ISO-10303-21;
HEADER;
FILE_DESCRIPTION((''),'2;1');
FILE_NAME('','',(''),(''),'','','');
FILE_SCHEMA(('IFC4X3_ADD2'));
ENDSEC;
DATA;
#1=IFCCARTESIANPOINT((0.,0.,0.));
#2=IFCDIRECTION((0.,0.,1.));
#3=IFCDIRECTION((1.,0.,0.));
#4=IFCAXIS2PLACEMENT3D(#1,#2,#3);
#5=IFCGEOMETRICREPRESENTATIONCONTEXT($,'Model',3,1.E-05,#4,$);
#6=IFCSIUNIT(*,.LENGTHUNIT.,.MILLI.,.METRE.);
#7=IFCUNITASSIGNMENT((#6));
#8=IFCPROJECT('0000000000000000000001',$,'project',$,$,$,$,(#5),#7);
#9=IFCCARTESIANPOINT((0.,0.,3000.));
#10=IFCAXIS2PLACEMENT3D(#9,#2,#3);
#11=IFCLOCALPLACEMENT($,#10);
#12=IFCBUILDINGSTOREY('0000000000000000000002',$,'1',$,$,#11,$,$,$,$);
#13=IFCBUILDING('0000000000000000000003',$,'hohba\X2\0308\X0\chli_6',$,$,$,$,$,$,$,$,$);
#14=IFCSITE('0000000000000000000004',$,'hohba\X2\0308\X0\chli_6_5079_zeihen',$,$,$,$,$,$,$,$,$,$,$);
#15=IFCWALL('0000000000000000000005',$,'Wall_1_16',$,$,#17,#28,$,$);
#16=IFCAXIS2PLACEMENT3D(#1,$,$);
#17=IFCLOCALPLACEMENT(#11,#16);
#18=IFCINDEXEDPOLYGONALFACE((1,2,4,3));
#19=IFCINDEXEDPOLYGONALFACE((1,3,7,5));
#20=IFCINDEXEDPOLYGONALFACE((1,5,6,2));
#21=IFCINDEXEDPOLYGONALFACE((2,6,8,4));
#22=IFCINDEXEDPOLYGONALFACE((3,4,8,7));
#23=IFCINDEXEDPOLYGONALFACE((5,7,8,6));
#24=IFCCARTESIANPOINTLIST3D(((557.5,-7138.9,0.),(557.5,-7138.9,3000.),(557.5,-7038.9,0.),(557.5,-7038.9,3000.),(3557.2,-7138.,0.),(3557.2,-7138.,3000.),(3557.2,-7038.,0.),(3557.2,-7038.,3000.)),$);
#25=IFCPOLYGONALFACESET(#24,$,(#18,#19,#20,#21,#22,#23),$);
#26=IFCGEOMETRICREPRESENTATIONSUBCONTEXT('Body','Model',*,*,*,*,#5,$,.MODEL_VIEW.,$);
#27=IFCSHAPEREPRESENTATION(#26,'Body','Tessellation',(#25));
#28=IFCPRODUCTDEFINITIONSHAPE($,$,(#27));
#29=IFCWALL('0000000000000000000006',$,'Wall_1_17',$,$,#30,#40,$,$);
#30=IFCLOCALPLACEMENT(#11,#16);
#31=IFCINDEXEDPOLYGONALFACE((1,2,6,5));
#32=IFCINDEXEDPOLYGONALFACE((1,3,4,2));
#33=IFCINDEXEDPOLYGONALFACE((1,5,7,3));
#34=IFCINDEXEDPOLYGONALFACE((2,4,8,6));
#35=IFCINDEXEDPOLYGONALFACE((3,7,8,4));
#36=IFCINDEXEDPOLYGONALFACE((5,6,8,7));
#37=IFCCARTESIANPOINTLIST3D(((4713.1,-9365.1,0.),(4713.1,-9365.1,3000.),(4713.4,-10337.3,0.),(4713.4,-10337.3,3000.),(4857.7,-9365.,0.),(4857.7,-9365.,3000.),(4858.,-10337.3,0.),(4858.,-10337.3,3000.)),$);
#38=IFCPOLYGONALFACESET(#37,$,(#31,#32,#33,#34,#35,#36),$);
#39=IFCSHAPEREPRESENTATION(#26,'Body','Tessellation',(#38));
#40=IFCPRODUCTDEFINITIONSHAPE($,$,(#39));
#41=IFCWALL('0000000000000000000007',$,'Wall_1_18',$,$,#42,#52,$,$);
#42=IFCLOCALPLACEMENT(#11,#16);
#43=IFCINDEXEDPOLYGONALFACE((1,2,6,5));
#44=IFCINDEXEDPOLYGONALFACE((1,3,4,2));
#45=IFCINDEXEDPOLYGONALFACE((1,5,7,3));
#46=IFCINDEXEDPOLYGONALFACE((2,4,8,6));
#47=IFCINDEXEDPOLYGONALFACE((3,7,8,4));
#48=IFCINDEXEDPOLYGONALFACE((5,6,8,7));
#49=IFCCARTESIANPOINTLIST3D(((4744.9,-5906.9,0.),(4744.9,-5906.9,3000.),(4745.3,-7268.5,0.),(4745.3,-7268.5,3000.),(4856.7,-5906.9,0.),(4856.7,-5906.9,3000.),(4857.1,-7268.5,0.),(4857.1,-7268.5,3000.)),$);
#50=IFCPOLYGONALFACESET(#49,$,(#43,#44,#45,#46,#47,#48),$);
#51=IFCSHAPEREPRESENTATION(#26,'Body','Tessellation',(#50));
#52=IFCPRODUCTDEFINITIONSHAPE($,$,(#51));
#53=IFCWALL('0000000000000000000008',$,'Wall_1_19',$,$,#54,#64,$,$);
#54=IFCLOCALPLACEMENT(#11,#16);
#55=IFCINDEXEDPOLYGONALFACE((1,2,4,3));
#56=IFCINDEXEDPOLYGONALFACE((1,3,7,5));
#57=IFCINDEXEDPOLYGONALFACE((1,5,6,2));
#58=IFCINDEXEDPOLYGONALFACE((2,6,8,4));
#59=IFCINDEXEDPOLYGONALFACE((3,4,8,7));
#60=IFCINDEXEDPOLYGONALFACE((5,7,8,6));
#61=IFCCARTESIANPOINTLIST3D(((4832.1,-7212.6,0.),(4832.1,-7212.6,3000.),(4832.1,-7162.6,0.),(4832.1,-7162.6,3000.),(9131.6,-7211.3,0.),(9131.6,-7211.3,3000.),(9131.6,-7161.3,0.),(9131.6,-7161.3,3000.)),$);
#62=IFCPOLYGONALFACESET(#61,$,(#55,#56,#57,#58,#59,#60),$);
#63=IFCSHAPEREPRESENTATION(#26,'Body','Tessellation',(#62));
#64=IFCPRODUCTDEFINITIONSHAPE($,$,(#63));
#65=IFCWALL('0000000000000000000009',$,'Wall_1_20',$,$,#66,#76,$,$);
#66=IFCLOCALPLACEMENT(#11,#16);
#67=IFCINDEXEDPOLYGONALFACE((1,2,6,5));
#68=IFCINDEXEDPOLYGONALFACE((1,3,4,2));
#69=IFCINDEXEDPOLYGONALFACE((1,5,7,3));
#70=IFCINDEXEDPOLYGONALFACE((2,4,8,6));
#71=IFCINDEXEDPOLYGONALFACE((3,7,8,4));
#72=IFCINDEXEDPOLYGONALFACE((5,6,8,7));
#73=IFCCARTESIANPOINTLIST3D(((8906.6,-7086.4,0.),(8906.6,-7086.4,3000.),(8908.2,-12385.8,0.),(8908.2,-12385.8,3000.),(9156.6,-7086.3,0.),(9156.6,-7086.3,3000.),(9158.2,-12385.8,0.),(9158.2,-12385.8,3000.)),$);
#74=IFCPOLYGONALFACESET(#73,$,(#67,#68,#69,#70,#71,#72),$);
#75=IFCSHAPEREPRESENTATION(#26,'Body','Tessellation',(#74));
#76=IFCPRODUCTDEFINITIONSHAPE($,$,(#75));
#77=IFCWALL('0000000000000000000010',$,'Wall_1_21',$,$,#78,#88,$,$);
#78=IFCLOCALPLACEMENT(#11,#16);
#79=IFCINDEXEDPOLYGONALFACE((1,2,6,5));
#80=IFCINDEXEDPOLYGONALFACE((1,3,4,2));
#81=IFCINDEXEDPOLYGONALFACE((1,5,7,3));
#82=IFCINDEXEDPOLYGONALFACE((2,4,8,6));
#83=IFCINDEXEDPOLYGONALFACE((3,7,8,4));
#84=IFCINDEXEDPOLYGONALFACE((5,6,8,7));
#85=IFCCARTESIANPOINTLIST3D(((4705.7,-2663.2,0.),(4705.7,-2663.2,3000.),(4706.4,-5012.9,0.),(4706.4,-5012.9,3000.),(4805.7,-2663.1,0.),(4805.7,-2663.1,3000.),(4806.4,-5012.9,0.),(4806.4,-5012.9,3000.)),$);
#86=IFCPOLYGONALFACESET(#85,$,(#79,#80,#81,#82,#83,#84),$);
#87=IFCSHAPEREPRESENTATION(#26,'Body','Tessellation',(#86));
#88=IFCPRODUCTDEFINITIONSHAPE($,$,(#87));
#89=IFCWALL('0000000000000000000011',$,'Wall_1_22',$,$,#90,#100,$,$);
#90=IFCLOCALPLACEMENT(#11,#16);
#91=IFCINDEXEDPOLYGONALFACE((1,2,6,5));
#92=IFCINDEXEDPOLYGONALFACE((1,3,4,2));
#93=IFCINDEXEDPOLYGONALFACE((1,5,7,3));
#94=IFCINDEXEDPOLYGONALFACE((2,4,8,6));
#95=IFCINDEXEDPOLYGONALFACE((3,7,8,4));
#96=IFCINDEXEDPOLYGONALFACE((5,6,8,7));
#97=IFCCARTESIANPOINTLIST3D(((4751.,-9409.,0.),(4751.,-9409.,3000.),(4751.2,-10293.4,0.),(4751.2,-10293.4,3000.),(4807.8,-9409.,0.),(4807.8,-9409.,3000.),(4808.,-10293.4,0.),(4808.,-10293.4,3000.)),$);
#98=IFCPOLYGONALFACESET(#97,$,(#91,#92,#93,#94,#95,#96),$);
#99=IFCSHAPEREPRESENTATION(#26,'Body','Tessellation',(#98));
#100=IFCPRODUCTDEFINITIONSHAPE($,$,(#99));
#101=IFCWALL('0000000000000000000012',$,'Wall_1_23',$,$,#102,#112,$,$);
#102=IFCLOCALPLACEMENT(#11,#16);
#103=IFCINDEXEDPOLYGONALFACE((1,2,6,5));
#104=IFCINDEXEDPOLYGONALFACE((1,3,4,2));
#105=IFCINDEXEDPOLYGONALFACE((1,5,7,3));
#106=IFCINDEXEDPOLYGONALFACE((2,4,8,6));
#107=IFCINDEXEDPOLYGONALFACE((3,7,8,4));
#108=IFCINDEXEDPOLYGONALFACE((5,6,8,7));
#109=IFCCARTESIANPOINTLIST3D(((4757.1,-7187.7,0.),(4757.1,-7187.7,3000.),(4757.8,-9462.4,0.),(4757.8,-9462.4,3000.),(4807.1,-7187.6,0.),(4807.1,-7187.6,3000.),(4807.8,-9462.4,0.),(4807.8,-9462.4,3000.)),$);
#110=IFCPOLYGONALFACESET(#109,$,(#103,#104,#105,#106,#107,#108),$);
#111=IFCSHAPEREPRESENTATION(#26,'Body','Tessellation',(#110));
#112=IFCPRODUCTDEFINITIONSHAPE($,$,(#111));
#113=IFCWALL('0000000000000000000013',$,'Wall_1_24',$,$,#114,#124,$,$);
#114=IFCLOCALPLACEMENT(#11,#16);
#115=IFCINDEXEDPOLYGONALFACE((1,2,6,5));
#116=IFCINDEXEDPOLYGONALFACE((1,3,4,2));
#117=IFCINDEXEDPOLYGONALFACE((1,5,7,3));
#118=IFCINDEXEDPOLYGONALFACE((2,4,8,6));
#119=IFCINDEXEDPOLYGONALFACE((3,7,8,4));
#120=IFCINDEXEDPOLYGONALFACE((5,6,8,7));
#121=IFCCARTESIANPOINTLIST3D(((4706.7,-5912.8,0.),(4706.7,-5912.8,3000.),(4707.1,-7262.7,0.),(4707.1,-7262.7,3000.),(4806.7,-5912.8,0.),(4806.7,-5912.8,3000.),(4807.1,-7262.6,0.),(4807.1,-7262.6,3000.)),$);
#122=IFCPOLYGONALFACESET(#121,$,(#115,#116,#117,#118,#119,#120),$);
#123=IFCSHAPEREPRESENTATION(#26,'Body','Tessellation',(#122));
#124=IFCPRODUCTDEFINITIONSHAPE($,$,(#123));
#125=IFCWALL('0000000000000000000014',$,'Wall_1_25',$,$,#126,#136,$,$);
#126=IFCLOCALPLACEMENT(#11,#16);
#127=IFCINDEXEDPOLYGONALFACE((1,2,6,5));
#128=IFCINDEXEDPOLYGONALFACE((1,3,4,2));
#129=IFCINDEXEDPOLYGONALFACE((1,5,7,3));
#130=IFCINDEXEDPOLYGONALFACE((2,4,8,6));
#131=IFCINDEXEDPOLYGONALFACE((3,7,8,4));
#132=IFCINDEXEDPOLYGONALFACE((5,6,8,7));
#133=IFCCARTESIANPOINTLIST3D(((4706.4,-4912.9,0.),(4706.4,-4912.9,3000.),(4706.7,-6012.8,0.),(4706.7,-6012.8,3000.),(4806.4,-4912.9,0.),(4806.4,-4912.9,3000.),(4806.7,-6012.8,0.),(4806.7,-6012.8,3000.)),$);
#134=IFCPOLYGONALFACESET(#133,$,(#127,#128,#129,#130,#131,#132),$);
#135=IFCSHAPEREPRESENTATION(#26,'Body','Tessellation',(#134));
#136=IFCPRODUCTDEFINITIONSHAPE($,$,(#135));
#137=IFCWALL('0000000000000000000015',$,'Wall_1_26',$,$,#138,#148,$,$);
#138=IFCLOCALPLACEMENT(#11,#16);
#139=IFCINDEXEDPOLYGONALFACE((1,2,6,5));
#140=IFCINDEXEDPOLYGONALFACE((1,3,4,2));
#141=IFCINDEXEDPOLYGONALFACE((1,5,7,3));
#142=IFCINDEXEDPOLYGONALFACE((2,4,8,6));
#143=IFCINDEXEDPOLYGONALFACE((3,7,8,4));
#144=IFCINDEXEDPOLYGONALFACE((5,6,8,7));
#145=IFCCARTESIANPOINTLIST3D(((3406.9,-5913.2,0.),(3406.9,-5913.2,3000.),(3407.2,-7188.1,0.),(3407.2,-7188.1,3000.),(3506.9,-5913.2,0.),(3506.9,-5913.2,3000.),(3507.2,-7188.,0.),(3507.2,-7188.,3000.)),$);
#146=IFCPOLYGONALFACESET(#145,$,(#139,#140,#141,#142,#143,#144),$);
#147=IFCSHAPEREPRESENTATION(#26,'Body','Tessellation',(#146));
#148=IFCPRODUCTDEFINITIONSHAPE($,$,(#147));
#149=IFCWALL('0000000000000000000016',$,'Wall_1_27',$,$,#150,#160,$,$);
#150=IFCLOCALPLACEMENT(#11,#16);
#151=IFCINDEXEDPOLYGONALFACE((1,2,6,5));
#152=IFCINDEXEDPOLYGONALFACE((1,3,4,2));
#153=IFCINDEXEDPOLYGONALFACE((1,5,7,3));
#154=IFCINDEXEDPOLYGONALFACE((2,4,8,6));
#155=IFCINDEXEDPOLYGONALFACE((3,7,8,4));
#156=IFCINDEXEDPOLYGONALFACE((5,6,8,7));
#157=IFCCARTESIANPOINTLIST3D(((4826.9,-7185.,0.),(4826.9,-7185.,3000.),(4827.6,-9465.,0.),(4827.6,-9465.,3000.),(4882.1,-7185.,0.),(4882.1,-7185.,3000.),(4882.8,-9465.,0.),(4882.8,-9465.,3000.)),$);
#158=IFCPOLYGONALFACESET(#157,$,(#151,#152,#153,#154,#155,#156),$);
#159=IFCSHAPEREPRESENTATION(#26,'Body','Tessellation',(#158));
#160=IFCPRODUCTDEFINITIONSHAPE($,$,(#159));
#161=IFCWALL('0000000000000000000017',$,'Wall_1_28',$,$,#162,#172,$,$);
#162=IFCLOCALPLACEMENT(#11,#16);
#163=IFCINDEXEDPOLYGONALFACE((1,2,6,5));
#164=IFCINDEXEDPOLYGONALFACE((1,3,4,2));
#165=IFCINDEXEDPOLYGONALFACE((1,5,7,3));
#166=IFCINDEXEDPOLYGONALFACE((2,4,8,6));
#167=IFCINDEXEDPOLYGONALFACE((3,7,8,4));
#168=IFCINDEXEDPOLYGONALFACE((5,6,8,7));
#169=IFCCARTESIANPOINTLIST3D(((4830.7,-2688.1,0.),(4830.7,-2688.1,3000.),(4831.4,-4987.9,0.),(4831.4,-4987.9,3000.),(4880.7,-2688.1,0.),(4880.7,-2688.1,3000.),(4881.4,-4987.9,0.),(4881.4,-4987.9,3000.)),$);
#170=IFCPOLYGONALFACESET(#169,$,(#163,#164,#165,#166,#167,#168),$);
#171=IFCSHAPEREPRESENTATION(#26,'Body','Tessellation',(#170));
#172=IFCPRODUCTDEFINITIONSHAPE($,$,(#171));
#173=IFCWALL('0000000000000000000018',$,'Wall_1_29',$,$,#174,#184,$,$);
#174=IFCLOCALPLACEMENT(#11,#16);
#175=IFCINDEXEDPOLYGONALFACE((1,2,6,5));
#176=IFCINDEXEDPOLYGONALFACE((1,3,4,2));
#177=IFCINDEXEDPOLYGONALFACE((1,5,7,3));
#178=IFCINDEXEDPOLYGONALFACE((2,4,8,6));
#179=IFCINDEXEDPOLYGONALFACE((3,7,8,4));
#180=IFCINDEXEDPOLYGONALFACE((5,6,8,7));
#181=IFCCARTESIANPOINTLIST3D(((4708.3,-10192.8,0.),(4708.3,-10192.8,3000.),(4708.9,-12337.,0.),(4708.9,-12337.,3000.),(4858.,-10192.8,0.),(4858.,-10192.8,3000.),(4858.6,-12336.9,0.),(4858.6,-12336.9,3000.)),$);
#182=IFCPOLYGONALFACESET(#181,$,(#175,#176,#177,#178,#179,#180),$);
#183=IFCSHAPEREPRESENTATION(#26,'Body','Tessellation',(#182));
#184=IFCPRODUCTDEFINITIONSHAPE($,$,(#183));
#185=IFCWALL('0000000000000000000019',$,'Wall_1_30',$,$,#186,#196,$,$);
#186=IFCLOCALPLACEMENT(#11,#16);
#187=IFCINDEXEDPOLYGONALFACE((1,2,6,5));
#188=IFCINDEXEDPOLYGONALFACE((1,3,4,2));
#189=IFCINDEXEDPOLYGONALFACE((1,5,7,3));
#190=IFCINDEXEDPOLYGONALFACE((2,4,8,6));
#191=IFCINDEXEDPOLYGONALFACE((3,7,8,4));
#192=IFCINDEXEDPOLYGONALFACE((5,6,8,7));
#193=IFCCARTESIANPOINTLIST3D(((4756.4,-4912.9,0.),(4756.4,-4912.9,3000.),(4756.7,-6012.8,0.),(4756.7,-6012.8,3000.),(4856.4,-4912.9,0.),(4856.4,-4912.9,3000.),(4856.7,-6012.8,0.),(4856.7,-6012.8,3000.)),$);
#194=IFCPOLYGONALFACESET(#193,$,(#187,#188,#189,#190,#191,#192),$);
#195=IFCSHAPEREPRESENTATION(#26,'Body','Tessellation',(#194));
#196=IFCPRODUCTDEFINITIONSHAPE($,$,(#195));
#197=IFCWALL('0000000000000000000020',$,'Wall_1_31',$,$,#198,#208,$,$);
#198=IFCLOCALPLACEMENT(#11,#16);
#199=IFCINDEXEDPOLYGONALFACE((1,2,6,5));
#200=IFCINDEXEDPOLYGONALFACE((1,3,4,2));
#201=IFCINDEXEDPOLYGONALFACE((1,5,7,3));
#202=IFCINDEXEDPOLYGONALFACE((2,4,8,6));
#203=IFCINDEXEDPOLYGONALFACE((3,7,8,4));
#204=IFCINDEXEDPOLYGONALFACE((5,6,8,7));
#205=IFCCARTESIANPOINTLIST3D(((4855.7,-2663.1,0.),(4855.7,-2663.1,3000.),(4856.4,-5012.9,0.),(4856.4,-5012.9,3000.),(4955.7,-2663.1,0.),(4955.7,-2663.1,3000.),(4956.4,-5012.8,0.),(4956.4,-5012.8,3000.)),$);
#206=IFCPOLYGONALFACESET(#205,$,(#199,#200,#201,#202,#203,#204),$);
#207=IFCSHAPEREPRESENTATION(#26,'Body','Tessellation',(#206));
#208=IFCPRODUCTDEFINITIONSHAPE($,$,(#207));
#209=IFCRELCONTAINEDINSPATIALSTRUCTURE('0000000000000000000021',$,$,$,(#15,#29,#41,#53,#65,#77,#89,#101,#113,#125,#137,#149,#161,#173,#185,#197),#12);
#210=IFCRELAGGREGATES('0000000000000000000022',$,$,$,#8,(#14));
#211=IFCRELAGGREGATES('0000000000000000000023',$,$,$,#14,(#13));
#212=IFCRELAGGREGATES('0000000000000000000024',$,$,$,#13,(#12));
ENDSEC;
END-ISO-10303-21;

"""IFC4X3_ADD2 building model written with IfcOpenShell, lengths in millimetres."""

from ifc_helpers import new_model, si_unit, frame, origin_with_axes, place, context, subcontext, project, spatial, indexed_curve, outline, extrude, element, save


model = new_model("IFC4X3_ADD2")

# Units and contexts
model_context = context("Model", 3, precision=1e-05, world=origin_with_axes())
body_context = subcontext(model_context, "Body", "Model", "MODEL_VIEW")
ifc_project = project(units=[si_unit("LENGTHUNIT", "METRE", prefix="MILLI")], contexts=[model_context])

# Site, building, storey
site = spatial("IfcSite", under=ifc_project, Name="hohbächli_6_5079_zeihen")
building = spatial("IfcBuilding", under=site, Name="hohbächli_6")
storey_placement = place(None, frame((0.0, 0.0, 3000.0), z_axis=(0.0, 0.0, 1.0), x_axis=(1.0, 0.0, 0.0)))
storey = spatial("IfcBuildingStorey", under=building, at=storey_placement, Name="1")

# Walls
wall_1_placement = place(storey_placement, frame((557.5, -7138.9, 0.0), z_axis=(0.0, 0.0, 1.0), x_axis=(1.0, 0.000302, 0.0)))
element("IfcWall", 1, at=wall_1_placement, inside=storey, Name="Wall_1_16", context=body_context, shape_type="SweptSolid", body=[
    extrude(outline(indexed_curve([(0.0, 0.0), (0.0, 100.0), (2999.7, 100.0), (2999.7, 0.0), (0.0, 0.0)], self_intersect=False)), origin_with_axes(), (0.0, 0.0, 1.0), 3000.0),
])
wall_2_placement = place(storey_placement, frame((4858.0, -10337.3, 0.0), z_axis=(0.0, 0.0, 1.0), x_axis=(-0.000302, 1.0, 0.0)))
element("IfcWall", 2, at=wall_2_placement, inside=storey, Name="Wall_1_17", context=body_context, shape_type="SweptSolid", body=[
    extrude(outline(indexed_curve([(0.0, 0.0), (0.0, 144.7), (972.3, 144.7), (972.3, 0.0), (0.0, 0.0)], self_intersect=False)), origin_with_axes(), (0.0, 0.0, 1.0), 3000.0),
])
wall_3_placement = place(storey_placement, frame((4857.1, -7268.5, 0.0), z_axis=(0.0, 0.0, 1.0), x_axis=(-0.000302, 1.0, 0.0)))
element("IfcWall", 3, at=wall_3_placement, inside=storey, Name="Wall_1_18", context=body_context, shape_type="SweptSolid", body=[
    extrude(outline(indexed_curve([(0.0, 0.0), (0.0, 111.8), (1361.7, 111.8), (1361.7, 0.0), (0.0, 0.0)], self_intersect=False)), origin_with_axes(), (0.0, 0.0, 1.0), 3000.0),
])
wall_4_placement = place(storey_placement, frame((9131.6, -7161.3, 0.0), z_axis=(0.0, 0.0, 1.0), x_axis=(-1.0, -0.000302, 0.0)))
element("IfcWall", 4, at=wall_4_placement, inside=storey, Name="Wall_1_19", context=body_context, shape_type="SweptSolid", body=[
    extrude(outline(indexed_curve([(0.0, 0.0), (0.0, 50.0), (4299.5, 50.0), (4299.5, 0.0), (0.0, 0.0)], self_intersect=False)), origin_with_axes(), (0.0, 0.0, 1.0), 3000.0),
])
wall_5_placement = place(storey_placement, frame((9158.2, -12385.8, 0.0), z_axis=(0.0, 0.0, 1.0), x_axis=(-0.000302, 1.0, 0.0)))
element("IfcWall", 5, at=wall_5_placement, inside=storey, Name="Wall_1_20", context=body_context, shape_type="SweptSolid", body=[
    extrude(outline(indexed_curve([(0.0, 0.0), (0.0, 250.0), (5299.4, 250.0), (5299.4, 0.0), (0.0, 0.0)], self_intersect=False)), origin_with_axes(), (0.0, 0.0, 1.0), 3000.0),
])
wall_6_placement = place(storey_placement, frame((4806.4, -5012.9, 0.0), z_axis=(0.0, 0.0, 1.0), x_axis=(-0.000302, 1.0, 0.0)))
element("IfcWall", 6, at=wall_6_placement, inside=storey, Name="Wall_1_21", context=body_context, shape_type="SweptSolid", body=[
    extrude(outline(indexed_curve([(0.0, 0.0), (0.0, 100.0), (2349.7, 100.0), (2349.7, 0.0), (0.0, 0.0)], self_intersect=False)), origin_with_axes(), (0.0, 0.0, 1.0), 3000.0),
])
wall_7_placement = place(storey_placement, frame((4808.0, -10293.4, 0.0), z_axis=(0.0, 0.0, 1.0), x_axis=(-0.000302, 1.0, 0.0)))
element("IfcWall", 7, at=wall_7_placement, inside=storey, Name="Wall_1_22", context=body_context, shape_type="SweptSolid", body=[
    extrude(outline(indexed_curve([(0.0, 0.0), (0.0, 56.8), (884.4, 56.8), (884.4, 0.0), (0.0, 0.0)], self_intersect=False)), origin_with_axes(), (0.0, 0.0, 1.0), 3000.0),
])
wall_8_placement = place(storey_placement, frame((4807.8, -9462.4, 0.0), z_axis=(0.0, 0.0, 1.0), x_axis=(-0.000302, 1.0, 0.0)))
element("IfcWall", 8, at=wall_8_placement, inside=storey, Name="Wall_1_23", context=body_context, shape_type="SweptSolid", body=[
    extrude(outline(indexed_curve([(0.0, 0.0), (0.0, 50.0), (2274.8, 50.0), (2274.8, 0.0), (0.0, 0.0)], self_intersect=False)), origin_with_axes(), (0.0, 0.0, 1.0), 3000.0),
])
wall_9_placement = place(storey_placement, frame((4807.1, -7262.6, 0.0), z_axis=(0.0, 0.0, 1.0), x_axis=(-0.000302, 1.0, 0.0)))
element("IfcWall", 9, at=wall_9_placement, inside=storey, Name="Wall_1_24", context=body_context, shape_type="SweptSolid", body=[
    extrude(outline(indexed_curve([(0.0, 0.0), (0.0, 100.0), (1349.9, 100.0), (1349.9, 0.0), (0.0, 0.0)], self_intersect=False)), origin_with_axes(), (0.0, 0.0, 1.0), 3000.0),
])
wall_10_placement = place(storey_placement, frame((4806.7, -6012.8, 0.0), z_axis=(0.0, 0.0, 1.0), x_axis=(-0.000302, 1.0, 0.0)))
element("IfcWall", 10, at=wall_10_placement, inside=storey, Name="Wall_1_25", context=body_context, shape_type="SweptSolid", body=[
    extrude(outline(indexed_curve([(0.0, 0.0), (0.0, 100.0), (1099.9, 100.0), (1099.9, 0.0), (0.0, 0.0)], self_intersect=False)), origin_with_axes(), (0.0, 0.0, 1.0), 3000.0),
])
wall_11_placement = place(storey_placement, frame((3507.2, -7188.0, 0.0), z_axis=(0.0, 0.0, 1.0), x_axis=(-0.000302, 1.0, 0.0)))
element("IfcWall", 11, at=wall_11_placement, inside=storey, Name="Wall_1_26", context=body_context, shape_type="SweptSolid", body=[
    extrude(outline(indexed_curve([(0.0, 0.0), (0.0, 100.0), (1274.9, 100.0), (1274.9, 0.0), (0.0, 0.0)], self_intersect=False)), origin_with_axes(), (0.0, 0.0, 1.0), 3000.0),
])
wall_12_placement = place(storey_placement, frame((4882.8, -9465.0, 0.0), z_axis=(0.0, 0.0, 1.0), x_axis=(-0.000302, 1.0, 0.0)))
element("IfcWall", 12, at=wall_12_placement, inside=storey, Name="Wall_1_27", context=body_context, shape_type="SweptSolid", body=[
    extrude(outline(indexed_curve([(0.0, 0.0), (0.0, 55.2), (2279.9, 55.2), (2279.9, 0.0), (0.0, 0.0)], self_intersect=False)), origin_with_axes(), (0.0, 0.0, 1.0), 3000.0),
])
wall_13_placement = place(storey_placement, frame((4881.4, -4987.9, 0.0), z_axis=(0.0, 0.0, 1.0), x_axis=(-0.000302, 1.0, 0.0)))
element("IfcWall", 13, at=wall_13_placement, inside=storey, Name="Wall_1_28", context=body_context, shape_type="SweptSolid", body=[
    extrude(outline(indexed_curve([(0.0, 0.0), (0.0, 50.0), (2299.7, 50.0), (2299.7, 0.0), (0.0, 0.0)], self_intersect=False)), origin_with_axes(), (0.0, 0.0, 1.0), 3000.0),
])
wall_14_placement = place(storey_placement, frame((4858.6, -12336.9, 0.0), z_axis=(0.0, 0.0, 1.0), x_axis=(-0.000302, 1.0, 0.0)))
element("IfcWall", 14, at=wall_14_placement, inside=storey, Name="Wall_1_29", context=body_context, shape_type="SweptSolid", body=[
    extrude(outline(indexed_curve([(0.0, 0.0), (0.0, 149.7), (2144.1, 149.7), (2144.1, 0.0), (0.0, 0.0)], self_intersect=False)), origin_with_axes(), (0.0, 0.0, 1.0), 3000.0),
])
wall_15_placement = place(storey_placement, frame((4856.7, -6012.8, 0.0), z_axis=(0.0, 0.0, 1.0), x_axis=(-0.000302, 1.0, 0.0)))
element("IfcWall", 15, at=wall_15_placement, inside=storey, Name="Wall_1_30", context=body_context, shape_type="SweptSolid", body=[
    extrude(outline(indexed_curve([(0.0, 0.0), (0.0, 100.0), (1099.9, 100.0), (1099.9, 0.0), (0.0, 0.0)], self_intersect=False)), origin_with_axes(), (0.0, 0.0, 1.0), 3000.0),
])
wall_16_placement = place(storey_placement, frame((4855.7, -2663.1, 0.0), z_axis=(0.0, 0.0, 1.0), x_axis=(0.000302, -1.0, 0.0)))
element("IfcWall", 16, at=wall_16_placement, inside=storey, Name="Wall_1_31", context=body_context, shape_type="SweptSolid", body=[
    extrude(outline(indexed_curve([(0.0, 0.0), (0.0, 100.0), (2349.7, 100.0), (2349.7, 0.0), (0.0, 0.0)], self_intersect=False)), origin_with_axes(), (0.0, 0.0, 1.0), 3000.0),
])

save(model, "model.ifc")
